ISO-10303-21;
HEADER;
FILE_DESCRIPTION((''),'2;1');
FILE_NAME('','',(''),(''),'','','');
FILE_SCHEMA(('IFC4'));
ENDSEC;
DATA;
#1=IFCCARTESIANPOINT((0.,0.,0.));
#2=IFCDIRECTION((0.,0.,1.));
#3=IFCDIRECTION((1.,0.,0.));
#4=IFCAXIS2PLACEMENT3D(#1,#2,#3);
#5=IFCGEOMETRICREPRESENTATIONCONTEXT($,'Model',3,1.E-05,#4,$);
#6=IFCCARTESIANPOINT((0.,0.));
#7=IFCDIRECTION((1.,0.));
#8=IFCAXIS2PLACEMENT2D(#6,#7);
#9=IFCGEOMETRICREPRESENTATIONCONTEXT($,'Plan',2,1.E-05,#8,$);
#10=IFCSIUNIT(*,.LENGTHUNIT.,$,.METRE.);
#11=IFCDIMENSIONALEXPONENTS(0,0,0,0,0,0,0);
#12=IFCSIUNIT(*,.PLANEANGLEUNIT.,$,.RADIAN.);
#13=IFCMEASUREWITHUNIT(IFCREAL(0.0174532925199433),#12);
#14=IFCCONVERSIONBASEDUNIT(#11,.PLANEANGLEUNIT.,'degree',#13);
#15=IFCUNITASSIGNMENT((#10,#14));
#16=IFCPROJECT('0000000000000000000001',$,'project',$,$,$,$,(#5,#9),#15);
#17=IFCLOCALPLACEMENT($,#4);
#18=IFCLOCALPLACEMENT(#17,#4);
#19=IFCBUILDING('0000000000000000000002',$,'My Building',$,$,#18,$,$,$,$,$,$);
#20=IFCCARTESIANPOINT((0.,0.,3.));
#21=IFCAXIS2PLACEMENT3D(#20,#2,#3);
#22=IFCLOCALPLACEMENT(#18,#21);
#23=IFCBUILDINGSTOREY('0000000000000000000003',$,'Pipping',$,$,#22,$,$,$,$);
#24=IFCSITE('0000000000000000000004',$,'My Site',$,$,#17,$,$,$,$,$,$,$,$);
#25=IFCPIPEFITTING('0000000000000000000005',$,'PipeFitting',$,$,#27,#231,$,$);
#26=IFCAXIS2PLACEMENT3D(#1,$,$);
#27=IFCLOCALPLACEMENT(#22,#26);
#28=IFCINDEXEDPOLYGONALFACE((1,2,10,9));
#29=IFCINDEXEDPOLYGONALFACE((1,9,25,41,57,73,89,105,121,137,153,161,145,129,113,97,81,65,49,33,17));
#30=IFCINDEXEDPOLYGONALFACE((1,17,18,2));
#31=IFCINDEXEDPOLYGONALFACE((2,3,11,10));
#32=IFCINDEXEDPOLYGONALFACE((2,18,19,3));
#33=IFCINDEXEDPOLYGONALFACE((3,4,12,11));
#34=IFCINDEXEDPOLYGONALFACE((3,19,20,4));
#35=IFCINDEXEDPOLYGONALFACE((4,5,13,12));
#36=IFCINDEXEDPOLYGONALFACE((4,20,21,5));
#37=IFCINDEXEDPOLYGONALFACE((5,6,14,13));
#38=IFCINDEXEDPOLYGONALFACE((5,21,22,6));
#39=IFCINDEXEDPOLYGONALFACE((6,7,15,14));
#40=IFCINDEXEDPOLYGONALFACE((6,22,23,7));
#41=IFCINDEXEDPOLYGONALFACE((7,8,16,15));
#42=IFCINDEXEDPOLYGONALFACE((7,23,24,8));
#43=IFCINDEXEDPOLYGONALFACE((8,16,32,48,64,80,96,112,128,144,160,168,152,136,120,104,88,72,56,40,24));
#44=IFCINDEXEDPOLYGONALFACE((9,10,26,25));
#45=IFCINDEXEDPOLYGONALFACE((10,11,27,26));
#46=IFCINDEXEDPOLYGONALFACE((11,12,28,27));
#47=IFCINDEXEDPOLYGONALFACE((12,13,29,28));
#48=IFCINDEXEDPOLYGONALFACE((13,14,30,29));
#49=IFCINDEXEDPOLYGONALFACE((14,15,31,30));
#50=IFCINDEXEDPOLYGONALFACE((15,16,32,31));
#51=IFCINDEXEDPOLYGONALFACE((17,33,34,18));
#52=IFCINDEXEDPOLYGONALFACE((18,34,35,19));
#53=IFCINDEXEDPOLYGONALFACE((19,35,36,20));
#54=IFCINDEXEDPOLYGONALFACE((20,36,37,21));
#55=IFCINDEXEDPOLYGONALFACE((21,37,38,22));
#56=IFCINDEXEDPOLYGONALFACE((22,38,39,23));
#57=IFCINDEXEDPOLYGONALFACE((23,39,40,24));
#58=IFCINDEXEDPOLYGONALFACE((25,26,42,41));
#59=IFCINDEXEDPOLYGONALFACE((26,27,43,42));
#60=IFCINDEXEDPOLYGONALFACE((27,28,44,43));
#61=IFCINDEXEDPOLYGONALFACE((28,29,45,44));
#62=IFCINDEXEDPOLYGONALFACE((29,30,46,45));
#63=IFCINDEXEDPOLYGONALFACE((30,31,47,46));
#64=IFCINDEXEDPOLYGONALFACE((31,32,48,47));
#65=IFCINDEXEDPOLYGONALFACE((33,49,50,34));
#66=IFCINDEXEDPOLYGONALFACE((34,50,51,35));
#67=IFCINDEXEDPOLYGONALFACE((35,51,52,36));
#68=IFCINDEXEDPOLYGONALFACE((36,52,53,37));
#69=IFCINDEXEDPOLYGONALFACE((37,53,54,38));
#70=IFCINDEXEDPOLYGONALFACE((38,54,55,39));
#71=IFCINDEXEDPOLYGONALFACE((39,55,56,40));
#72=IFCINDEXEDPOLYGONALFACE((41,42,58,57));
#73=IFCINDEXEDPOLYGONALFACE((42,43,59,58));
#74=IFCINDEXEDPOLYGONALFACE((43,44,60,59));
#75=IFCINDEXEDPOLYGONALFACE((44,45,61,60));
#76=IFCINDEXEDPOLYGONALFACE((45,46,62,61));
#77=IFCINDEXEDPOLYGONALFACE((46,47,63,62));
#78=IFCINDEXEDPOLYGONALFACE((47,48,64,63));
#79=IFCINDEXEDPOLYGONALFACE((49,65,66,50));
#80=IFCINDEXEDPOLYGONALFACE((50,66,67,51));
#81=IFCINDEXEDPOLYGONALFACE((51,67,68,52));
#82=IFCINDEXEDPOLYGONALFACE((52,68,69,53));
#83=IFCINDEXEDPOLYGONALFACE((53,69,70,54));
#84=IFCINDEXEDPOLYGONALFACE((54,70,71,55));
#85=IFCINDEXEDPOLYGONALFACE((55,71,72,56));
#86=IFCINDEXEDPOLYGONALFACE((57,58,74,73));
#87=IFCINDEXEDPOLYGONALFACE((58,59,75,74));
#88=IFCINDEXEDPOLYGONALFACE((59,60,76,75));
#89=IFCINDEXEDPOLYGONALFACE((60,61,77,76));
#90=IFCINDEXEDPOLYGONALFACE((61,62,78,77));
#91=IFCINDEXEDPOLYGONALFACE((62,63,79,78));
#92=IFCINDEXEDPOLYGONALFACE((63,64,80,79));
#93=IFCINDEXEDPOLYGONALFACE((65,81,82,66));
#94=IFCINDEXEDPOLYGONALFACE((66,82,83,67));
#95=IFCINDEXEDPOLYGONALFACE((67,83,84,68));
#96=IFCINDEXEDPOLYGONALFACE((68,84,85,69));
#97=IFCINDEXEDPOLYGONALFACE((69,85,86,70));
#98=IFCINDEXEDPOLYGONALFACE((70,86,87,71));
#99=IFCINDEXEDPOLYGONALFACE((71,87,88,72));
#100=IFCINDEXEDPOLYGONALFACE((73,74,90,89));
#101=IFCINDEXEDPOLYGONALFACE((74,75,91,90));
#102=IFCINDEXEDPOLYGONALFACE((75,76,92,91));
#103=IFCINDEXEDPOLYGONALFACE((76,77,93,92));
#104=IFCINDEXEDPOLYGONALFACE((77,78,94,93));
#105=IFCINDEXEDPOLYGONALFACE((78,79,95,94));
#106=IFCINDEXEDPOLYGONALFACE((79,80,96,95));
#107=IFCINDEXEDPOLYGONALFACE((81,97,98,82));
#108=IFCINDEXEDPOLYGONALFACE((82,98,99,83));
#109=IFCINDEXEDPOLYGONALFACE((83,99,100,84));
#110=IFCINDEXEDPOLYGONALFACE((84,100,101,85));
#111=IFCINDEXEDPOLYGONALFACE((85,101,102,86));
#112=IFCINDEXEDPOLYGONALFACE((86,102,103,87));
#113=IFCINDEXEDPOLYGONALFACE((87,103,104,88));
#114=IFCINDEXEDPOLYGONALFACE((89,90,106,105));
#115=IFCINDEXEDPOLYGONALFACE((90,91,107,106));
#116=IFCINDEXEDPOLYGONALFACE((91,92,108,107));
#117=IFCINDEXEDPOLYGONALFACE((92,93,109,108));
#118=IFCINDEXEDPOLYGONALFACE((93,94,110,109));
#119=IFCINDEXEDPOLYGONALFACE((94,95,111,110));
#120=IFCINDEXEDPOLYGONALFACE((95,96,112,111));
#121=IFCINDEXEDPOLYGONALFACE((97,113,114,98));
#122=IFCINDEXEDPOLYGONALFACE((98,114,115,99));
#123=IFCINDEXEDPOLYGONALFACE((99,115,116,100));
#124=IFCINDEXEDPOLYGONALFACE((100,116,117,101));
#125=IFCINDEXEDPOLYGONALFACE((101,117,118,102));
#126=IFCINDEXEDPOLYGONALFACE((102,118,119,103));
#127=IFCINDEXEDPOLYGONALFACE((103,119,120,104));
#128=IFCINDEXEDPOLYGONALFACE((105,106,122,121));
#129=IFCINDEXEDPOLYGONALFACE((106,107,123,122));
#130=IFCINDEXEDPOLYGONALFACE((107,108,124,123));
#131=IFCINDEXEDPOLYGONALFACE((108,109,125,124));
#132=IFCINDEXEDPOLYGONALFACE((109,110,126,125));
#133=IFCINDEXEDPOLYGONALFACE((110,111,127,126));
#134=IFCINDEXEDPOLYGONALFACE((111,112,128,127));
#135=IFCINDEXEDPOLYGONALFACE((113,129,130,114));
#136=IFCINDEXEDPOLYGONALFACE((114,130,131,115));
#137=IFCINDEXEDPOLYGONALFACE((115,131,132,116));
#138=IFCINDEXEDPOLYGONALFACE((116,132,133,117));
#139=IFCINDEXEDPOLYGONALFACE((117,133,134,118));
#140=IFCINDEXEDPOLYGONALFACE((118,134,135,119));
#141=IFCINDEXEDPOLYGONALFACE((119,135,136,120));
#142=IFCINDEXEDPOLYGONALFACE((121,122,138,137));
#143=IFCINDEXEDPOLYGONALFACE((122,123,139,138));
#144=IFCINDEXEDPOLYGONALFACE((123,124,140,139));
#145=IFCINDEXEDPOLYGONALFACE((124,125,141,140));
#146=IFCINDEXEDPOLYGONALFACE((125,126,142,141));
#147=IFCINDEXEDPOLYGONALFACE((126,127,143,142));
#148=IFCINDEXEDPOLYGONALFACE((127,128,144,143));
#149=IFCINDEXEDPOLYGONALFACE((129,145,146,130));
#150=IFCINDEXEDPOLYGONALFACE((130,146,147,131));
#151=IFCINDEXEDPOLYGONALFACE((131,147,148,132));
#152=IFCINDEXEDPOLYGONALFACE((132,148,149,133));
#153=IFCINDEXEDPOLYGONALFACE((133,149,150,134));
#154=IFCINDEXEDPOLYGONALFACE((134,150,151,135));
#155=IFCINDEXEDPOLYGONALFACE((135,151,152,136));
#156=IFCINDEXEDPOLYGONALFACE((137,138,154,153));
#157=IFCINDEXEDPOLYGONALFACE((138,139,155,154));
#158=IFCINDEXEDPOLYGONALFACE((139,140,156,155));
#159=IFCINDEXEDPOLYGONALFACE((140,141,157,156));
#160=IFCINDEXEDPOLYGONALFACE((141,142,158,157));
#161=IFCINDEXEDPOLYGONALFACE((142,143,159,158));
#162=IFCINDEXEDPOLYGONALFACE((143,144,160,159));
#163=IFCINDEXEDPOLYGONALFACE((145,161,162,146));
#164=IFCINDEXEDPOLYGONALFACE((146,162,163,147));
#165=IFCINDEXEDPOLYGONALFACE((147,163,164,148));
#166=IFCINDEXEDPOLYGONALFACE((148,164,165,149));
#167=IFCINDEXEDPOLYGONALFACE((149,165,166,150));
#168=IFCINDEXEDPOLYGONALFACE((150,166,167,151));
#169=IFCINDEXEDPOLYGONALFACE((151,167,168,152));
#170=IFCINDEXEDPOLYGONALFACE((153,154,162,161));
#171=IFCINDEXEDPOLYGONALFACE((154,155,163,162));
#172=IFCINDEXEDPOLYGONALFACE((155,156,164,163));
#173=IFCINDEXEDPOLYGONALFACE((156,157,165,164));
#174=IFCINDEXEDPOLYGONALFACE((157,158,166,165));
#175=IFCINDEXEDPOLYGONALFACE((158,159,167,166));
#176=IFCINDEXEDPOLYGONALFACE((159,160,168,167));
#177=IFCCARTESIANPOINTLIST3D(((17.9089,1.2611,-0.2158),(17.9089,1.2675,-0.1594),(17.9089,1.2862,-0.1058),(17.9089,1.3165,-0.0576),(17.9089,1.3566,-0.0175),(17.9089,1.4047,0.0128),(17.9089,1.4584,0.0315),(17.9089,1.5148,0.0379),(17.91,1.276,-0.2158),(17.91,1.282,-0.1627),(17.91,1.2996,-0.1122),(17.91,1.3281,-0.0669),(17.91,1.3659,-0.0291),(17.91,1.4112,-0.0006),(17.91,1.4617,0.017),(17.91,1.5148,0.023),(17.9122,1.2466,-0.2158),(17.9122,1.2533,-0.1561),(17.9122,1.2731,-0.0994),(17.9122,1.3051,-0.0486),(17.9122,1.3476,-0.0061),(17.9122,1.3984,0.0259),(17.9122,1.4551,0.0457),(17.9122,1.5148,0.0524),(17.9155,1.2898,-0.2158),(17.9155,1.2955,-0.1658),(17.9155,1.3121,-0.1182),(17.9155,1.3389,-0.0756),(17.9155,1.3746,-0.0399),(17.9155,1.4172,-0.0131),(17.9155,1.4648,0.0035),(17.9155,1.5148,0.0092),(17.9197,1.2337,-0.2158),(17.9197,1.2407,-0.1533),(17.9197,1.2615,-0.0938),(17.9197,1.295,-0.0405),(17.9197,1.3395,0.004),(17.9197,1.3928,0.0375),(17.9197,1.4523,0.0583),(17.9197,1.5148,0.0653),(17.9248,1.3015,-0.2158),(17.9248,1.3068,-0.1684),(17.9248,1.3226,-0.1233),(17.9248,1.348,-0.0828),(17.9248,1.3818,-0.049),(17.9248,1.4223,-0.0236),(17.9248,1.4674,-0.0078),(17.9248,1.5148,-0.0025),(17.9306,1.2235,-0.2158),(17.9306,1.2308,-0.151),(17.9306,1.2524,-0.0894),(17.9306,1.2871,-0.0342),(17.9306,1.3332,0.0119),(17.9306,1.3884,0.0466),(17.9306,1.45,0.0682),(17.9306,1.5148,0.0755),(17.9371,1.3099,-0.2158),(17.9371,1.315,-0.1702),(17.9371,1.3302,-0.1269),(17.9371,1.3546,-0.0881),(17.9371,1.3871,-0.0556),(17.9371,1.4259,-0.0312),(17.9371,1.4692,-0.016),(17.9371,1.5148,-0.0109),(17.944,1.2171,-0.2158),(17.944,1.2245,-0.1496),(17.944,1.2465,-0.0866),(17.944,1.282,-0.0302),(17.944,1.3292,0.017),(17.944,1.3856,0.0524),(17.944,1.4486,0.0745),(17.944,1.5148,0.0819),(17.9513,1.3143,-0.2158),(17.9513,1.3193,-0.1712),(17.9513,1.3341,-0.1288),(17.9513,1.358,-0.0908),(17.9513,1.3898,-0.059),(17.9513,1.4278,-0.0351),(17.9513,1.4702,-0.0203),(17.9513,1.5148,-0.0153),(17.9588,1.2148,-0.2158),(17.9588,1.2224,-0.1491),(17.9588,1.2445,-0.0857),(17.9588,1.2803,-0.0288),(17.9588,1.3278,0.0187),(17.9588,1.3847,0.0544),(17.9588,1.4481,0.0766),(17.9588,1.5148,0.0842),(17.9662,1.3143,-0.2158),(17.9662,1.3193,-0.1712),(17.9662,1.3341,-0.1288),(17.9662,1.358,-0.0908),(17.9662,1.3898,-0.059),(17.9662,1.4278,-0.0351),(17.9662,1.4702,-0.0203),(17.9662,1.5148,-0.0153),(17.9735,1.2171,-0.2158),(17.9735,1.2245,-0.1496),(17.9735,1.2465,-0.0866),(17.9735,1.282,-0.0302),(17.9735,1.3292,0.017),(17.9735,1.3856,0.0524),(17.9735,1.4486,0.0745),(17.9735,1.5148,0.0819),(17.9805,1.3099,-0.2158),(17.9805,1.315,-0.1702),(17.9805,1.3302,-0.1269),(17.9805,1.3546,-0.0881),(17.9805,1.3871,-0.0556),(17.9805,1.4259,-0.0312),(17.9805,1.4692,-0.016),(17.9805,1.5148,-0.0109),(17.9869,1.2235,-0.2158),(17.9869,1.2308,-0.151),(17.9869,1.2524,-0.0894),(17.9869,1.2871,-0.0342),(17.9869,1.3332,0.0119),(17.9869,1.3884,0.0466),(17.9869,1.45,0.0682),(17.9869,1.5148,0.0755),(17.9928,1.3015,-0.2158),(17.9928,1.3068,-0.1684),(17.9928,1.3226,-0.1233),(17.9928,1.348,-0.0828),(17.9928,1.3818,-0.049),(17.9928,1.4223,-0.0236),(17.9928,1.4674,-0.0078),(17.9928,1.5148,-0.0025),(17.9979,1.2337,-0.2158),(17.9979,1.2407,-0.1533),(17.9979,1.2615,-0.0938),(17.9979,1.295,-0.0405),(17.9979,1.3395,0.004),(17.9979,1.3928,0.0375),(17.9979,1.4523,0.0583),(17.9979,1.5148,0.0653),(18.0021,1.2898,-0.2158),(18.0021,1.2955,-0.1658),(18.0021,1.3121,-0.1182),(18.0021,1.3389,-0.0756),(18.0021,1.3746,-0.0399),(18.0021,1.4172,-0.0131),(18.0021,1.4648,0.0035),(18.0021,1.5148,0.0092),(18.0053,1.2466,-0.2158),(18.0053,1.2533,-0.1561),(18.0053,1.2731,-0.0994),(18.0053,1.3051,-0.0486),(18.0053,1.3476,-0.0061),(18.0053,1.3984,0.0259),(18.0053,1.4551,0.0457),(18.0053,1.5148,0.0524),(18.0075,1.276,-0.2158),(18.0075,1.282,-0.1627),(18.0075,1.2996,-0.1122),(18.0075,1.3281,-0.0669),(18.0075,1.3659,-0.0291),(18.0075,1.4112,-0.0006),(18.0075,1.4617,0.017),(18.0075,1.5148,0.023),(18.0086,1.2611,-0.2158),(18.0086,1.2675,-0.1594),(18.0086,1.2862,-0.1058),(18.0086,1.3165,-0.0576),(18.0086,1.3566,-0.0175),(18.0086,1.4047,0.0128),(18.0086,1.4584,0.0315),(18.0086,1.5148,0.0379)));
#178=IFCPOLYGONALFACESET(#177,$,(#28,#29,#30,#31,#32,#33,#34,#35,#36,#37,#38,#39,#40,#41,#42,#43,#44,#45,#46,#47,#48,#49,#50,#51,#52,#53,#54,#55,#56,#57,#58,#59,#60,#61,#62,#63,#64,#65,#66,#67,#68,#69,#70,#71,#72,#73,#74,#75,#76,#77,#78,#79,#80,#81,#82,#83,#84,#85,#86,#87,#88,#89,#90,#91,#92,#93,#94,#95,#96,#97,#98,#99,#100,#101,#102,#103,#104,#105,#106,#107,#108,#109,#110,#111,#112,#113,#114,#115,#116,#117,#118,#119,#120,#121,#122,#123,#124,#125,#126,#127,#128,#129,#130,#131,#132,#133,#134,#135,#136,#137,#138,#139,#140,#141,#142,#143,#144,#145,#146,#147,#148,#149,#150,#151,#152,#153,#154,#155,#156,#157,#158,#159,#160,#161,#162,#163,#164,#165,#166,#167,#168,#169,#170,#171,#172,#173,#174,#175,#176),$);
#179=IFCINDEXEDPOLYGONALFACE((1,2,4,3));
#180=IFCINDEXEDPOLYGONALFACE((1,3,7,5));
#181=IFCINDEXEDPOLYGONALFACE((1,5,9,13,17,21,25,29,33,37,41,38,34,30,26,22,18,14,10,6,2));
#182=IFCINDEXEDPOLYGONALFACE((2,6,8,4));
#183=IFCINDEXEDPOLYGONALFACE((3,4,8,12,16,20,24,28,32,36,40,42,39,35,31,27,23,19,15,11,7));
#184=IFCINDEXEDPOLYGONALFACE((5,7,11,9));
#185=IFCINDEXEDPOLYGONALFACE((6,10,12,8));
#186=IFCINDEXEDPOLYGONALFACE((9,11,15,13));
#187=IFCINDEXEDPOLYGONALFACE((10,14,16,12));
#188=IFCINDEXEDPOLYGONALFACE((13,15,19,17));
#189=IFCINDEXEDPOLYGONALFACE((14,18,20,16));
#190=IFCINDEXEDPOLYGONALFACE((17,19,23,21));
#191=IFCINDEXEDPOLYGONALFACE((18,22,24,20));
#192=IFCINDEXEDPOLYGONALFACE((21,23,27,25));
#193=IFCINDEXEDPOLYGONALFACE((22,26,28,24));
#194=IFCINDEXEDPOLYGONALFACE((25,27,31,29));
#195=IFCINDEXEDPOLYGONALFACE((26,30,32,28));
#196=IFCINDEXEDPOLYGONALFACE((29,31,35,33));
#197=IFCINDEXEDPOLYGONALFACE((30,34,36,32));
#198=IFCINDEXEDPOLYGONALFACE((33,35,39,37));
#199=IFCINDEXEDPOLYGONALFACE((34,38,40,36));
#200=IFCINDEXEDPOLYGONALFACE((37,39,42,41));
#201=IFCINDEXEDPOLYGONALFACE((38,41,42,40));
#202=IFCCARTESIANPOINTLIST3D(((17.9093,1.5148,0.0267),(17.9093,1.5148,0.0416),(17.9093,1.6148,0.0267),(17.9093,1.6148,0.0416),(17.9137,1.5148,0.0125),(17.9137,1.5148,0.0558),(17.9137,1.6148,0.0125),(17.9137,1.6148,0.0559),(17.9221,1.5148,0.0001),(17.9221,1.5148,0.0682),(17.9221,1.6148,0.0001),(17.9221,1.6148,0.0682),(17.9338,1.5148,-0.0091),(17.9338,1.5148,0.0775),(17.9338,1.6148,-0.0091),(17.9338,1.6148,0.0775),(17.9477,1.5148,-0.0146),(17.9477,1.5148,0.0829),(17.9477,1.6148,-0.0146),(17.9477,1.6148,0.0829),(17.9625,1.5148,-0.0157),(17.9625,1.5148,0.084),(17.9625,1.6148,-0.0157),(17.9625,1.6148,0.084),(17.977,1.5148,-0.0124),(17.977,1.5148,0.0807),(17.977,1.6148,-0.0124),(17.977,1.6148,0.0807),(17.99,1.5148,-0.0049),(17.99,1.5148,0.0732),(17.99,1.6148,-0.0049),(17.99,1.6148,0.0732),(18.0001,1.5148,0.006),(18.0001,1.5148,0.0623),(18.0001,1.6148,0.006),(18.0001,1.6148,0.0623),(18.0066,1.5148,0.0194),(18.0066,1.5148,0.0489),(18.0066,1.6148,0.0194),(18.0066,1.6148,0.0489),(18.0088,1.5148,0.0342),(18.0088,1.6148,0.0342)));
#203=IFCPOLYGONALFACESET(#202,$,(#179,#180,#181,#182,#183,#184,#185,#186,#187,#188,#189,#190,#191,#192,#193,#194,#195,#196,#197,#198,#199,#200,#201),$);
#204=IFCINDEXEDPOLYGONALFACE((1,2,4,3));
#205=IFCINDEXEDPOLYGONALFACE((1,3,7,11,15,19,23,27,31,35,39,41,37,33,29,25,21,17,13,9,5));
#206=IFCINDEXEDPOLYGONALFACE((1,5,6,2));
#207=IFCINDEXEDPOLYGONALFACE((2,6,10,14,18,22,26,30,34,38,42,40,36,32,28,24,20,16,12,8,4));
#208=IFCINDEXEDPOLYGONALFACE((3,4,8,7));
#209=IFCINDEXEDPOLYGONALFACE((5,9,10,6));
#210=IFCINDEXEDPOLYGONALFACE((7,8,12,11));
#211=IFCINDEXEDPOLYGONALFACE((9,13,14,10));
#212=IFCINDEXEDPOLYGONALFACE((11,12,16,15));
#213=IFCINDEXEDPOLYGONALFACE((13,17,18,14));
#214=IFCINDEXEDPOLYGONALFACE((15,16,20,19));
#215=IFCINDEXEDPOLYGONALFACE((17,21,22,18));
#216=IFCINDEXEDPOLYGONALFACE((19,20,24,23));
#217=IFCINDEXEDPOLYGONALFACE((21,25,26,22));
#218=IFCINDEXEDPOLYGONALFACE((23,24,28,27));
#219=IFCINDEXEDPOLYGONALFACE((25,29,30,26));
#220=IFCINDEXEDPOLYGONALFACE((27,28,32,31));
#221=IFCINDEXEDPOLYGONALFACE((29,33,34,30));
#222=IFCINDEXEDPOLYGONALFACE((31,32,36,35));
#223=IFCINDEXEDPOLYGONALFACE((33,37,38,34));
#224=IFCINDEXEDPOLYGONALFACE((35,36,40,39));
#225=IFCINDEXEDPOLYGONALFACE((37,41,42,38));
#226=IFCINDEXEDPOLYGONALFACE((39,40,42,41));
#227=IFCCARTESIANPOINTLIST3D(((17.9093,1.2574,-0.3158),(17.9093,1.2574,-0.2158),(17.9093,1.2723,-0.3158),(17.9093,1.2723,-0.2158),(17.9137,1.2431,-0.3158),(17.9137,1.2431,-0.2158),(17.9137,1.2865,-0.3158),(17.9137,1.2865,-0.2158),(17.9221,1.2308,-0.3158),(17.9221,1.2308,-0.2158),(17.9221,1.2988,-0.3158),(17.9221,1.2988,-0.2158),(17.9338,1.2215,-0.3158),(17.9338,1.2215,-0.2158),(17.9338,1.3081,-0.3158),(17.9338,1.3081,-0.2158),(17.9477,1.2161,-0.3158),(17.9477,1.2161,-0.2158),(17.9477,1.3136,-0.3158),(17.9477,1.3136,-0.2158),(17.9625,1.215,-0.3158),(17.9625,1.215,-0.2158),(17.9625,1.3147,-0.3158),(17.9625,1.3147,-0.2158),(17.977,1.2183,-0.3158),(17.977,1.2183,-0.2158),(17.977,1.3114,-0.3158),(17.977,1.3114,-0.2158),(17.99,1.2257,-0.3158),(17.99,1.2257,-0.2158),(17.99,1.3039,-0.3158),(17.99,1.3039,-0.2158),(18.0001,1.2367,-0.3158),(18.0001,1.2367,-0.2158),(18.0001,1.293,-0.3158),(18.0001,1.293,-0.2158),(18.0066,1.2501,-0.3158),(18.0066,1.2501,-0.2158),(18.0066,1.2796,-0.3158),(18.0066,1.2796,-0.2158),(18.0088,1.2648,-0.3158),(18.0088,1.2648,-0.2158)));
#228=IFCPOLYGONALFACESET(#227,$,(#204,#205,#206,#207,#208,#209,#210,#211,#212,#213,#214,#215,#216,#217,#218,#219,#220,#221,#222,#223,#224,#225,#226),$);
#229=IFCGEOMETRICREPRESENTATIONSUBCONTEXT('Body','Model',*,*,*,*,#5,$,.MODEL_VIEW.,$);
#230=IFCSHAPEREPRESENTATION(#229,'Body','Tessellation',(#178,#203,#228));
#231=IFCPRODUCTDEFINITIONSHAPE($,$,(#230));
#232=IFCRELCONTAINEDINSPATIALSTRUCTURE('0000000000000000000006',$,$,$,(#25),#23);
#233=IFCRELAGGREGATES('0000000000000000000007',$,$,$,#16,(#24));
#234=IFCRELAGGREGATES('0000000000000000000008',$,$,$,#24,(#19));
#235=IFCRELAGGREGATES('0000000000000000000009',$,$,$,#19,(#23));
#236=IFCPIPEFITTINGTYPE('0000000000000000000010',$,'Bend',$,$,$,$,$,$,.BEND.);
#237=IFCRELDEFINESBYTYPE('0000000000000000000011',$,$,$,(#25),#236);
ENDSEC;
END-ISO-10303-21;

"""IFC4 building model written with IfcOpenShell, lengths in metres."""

from ifc_helpers import new_model, entity, si_unit, converted_unit, frame, origin_with_axes, origin_2d_with_axis, place, context, subcontext, project, spatial, circle, extrude, source, transform, mapped, type_object, type_shapes, element, save


model = new_model("IFC4")

# Units and contexts
model_context = context("Model", 3, precision=1e-05, world=origin_with_axes())
plan_context = context("Plan", 2, precision=1e-05, world=origin_2d_with_axis())
body_context = subcontext(model_context, "Body", "Model", "MODEL_VIEW")
ifc_project = project(units=[si_unit("LENGTHUNIT", "METRE"), converted_unit("PLANEANGLEUNIT", "degree", entity("IfcReal", 0.0174532925199433), si_unit("PLANEANGLEUNIT", "RADIAN"), dimensions=[0, 0, 0, 0, 0, 0, 0])], contexts=[model_context, plan_context])

# Site, building, storey
site_placement = place(None, origin_with_axes())
site = spatial("IfcSite", under=ifc_project, at=site_placement, Name="My Site")
building_placement = place(site_placement, origin_with_axes())
building = spatial("IfcBuilding", under=site, at=building_placement, Name="My Building")
storey_placement = place(building_placement, frame((0.0, 0.0, 3.0), z_axis=(0.0, 0.0, 1.0), x_axis=(1.0, 0.0, 0.0)))
storey = spatial("IfcBuildingStorey", under=building, at=storey_placement, Name="Pipping")

# Pipe fitting
pipe_fitting_type_1 = type_object("IfcPipeFittingType", Name="Bend", PredefinedType="BEND")
shared_shape_1 = source(origin_with_axes(), body_context, "Body", "SolidModel", [
    entity("IfcSweptDiskSolid", entity("IfcIndexedPolyCurve", entity("IfcCartesianPointList3D", [[0.0, 0.0, 0.1], [0.0, -0.0732, 0.2768], [0.0, -0.25, 0.35]]), [entity("IfcArcIndex", [1, 2, 3])]), 0.05),
    extrude(circle(Radius=0.05), origin_with_axes(), (0.0, 0.0, 1.0), 0.1),
    extrude(circle(Radius=0.05), frame((0.0, -0.25, 0.35), z_axis=(0.0, -1.0, 0.000004), x_axis=(1.0, 0.0, 0.0)), (0.0, 0.0, 1.0), 0.1),
])
type_shapes(pipe_fitting_type_1, [shared_shape_1])
for number, where, z_axis, x_axis, name in (
    (1, (17.9588, 1.6148, 0.0342), (0.0, -1.0, -0.000004), (1.0, 0.0, 0.0), "PipeFitting"),
):
    element("IfcPipeFitting", number, at=place(storey_placement, frame(where, z_axis=z_axis, x_axis=x_axis)), inside=storey, type_object=pipe_fitting_type_1, Name=name, context=body_context, shape_type="MappedRepresentation", body=[
        mapped(shared_shape_1, transform((0.0, 0.0, 0.0), x_axis=(1.0, 0.0, 0.0), y_axis=(0.0, 1.0, 0.0), z_axis=(0.0, 0.0, 1.0), scale=1.0)),
    ])

save(model, "model.ifc")
